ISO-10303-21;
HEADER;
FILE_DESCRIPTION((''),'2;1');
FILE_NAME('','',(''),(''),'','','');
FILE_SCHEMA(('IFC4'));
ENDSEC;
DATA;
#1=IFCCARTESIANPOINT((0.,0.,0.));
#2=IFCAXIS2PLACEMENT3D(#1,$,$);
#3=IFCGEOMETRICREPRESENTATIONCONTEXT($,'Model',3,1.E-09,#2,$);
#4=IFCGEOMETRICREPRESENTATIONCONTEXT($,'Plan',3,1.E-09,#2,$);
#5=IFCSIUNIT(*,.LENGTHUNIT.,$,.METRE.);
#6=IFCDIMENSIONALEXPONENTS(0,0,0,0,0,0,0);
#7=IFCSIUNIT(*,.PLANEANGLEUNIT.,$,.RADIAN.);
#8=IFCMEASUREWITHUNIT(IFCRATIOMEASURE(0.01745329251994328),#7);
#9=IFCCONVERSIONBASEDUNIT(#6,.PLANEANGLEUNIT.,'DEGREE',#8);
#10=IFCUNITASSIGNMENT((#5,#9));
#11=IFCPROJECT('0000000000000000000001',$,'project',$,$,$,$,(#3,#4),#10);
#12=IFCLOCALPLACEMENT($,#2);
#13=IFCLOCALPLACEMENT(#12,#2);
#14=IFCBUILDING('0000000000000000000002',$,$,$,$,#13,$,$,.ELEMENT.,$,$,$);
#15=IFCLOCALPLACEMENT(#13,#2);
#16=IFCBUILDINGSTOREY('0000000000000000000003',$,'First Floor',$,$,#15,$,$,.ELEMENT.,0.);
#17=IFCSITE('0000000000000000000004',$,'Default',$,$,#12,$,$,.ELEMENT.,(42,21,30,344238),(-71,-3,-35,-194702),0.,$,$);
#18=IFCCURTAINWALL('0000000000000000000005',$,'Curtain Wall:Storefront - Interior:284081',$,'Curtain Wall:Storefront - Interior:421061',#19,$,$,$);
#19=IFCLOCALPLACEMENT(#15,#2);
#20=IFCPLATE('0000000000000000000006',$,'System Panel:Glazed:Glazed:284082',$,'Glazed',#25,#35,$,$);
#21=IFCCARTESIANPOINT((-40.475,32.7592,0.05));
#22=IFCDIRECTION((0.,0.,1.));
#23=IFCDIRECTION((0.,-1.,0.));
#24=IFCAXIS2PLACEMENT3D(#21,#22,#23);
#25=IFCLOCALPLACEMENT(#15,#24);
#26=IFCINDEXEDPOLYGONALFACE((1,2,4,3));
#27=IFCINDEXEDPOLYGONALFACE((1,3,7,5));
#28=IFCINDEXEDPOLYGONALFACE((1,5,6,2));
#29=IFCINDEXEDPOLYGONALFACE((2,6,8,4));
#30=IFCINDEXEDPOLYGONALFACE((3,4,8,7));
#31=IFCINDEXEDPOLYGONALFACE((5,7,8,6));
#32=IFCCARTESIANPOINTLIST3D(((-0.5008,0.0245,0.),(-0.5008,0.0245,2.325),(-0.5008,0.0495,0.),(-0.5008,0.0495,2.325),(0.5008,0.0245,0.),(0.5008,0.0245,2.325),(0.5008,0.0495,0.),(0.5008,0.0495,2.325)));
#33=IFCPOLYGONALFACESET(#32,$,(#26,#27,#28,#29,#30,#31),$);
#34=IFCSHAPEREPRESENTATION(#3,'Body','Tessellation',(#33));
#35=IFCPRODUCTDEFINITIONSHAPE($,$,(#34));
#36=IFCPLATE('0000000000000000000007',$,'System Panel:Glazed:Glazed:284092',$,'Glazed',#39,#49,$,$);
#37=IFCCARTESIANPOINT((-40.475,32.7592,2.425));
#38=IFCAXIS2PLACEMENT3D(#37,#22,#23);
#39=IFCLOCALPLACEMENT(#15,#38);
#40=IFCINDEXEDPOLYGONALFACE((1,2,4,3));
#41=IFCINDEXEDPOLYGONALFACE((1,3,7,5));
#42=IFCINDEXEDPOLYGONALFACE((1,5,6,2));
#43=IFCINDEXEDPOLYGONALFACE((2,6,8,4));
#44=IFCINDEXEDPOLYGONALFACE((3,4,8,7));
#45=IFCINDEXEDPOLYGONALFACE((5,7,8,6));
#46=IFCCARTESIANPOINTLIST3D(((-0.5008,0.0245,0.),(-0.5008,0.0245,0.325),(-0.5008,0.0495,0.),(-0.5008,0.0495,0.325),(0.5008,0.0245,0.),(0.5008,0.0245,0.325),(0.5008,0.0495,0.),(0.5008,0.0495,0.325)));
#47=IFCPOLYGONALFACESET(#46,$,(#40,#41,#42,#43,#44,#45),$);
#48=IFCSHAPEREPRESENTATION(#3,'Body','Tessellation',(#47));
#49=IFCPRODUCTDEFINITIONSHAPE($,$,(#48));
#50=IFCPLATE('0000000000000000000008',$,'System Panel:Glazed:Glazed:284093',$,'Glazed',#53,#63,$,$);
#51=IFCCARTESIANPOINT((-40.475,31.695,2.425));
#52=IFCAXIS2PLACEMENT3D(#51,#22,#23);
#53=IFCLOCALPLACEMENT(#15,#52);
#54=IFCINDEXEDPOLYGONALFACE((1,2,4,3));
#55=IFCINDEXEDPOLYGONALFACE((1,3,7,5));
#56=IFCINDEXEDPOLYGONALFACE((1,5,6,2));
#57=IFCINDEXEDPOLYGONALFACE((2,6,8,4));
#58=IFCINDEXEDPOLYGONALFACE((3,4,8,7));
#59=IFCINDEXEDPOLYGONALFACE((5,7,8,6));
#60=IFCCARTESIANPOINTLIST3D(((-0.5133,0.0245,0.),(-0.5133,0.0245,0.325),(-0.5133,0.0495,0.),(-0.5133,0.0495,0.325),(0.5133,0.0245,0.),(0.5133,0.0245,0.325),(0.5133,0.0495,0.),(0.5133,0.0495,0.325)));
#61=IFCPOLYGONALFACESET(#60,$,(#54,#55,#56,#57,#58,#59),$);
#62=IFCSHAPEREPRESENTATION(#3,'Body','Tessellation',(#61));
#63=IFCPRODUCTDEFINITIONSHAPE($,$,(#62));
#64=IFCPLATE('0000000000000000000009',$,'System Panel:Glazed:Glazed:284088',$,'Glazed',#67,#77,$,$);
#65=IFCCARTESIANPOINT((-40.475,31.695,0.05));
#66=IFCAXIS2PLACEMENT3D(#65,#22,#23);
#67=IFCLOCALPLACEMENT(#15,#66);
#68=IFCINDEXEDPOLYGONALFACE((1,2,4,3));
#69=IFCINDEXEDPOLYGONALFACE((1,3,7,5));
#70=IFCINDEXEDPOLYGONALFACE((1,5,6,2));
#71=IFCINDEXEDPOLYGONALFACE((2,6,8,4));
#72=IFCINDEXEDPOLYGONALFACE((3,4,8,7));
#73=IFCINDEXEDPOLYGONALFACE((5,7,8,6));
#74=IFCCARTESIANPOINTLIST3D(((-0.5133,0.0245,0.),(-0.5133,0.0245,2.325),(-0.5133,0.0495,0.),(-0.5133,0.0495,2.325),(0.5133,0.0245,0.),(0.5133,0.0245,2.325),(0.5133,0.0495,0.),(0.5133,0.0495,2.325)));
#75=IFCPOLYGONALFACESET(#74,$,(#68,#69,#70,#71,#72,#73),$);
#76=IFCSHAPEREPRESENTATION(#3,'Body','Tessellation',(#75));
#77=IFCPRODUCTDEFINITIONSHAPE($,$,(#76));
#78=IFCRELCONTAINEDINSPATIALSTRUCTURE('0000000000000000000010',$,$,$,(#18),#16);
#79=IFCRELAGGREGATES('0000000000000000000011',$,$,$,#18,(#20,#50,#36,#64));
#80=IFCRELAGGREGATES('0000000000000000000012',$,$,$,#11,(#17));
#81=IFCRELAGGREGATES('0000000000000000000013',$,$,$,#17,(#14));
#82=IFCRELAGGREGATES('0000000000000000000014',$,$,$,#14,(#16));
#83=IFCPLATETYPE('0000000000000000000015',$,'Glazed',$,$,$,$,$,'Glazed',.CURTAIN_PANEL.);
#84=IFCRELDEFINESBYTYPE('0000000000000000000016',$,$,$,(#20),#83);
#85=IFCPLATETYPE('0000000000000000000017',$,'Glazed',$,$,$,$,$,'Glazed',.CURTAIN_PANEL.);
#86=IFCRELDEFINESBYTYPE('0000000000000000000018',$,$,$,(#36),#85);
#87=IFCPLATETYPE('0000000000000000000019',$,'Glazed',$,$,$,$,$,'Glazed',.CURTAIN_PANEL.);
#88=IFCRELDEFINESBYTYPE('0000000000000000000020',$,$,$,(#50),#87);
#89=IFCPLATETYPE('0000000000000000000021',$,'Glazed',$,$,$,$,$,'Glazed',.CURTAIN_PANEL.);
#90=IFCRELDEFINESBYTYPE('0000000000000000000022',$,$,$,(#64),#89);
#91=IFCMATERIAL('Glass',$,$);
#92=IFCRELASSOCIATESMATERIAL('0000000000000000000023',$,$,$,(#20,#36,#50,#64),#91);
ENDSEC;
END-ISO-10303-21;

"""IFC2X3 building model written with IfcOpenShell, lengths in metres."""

from ifc_helpers import new_model, entity, si_unit, converted_unit, frame, origin, origin_2d_with_axis, place, context, project, spatial, rectangle, extrude, source, transform, mapped, material, type_object, type_shapes, element, aggregate, save


model = new_model("IFC2X3")

# Units and contexts
model_context = context("Model", 3, precision=1e-09, world=origin())
plan_context = context("Plan", 3, precision=1e-09, world=origin())
ifc_project = project(units=[si_unit("LENGTHUNIT", "METRE"), converted_unit("PLANEANGLEUNIT", "DEGREE", entity("IfcRatioMeasure", 0.01745329251994328), si_unit("PLANEANGLEUNIT", "RADIAN"), dimensions=[0, 0, 0, 0, 0, 0, 0])], contexts=[model_context, plan_context])

# Site, building, storey
site_placement = place(None, origin())
site = spatial("IfcSite", under=ifc_project, at=site_placement, Name="Default", CompositionType="ELEMENT", RefLatitude=(42, 21, 30, 344238), RefLongitude=(-71, -3, -35, -194702), RefElevation=0.0)
building_placement = place(site_placement, origin())
building = spatial("IfcBuilding", under=site, at=building_placement, CompositionType="ELEMENT")
storey_placement = place(building_placement, origin())
storey = spatial("IfcBuildingStorey", under=building, at=storey_placement, Name="First Floor", CompositionType="ELEMENT", Elevation=0.0)

# Curtain wall, plates
curtain_wall_placement = place(storey_placement, origin())
curtain_wall = element("IfcCurtainWall", 1, at=curtain_wall_placement, inside=storey, Name="Curtain Wall:Storefront - Interior:284081", ObjectType="Curtain Wall:Storefront - Interior:421061")
ifc_material_1 = material(Name="Glass")
plate_type_1 = type_object("IfcPlateType", Name="Glazed", ElementType="Glazed", PredefinedType="CURTAIN_PANEL")
shared_shape_1 = source(origin(), model_context, "Body", "SweptSolid", [
    extrude(rectangle(XDim=0.025, YDim=1.0017, at=origin_2d_with_axis()), frame((0.0, 0.037, 0.0), z_axis=(0.0, 0.0, 1.0), x_axis=(0.0, 1.0, 0.0)), (0.0, 0.0, 1.0), 2.325),
])
type_shapes(plate_type_1, [shared_shape_1])
plate_1_placement = place(storey_placement, frame((-40.475, 32.7592, 0.05), z_axis=(0.0, 0.0, 1.0), x_axis=(0.0, -1.0, 0.0)))
plate_1 = element("IfcPlate", 2, at=plate_1_placement, type_object=plate_type_1, material=ifc_material_1, Name="System Panel:Glazed:Glazed:284082", ObjectType="Glazed", context=model_context, shape_type="MappedRepresentation", body=[
    mapped(shared_shape_1, transform((0.0, 0.0, 0.0), scale=1.0)),
])
plate_type_2 = type_object("IfcPlateType", Name="Glazed", ElementType="Glazed", PredefinedType="CURTAIN_PANEL")
shared_shape_2 = source(origin(), model_context, "Body", "SweptSolid", [
    extrude(rectangle(XDim=0.025, YDim=1.0017, at=origin_2d_with_axis()), frame((0.0, 0.037, 0.0), z_axis=(0.0, 0.0, 1.0), x_axis=(0.0, 1.0, 0.0)), (0.0, 0.0, 1.0), 0.325),
])
type_shapes(plate_type_2, [shared_shape_2])
plate_2_placement = place(storey_placement, frame((-40.475, 32.7592, 2.425), z_axis=(0.0, 0.0, 1.0), x_axis=(0.0, -1.0, 0.0)))
plate_2 = element("IfcPlate", 3, at=plate_2_placement, type_object=plate_type_2, material=ifc_material_1, Name="System Panel:Glazed:Glazed:284092", ObjectType="Glazed", context=model_context, shape_type="MappedRepresentation", body=[
    mapped(shared_shape_2, transform((0.0, 0.0, 0.0), scale=1.0)),
])
plate_type_3 = type_object("IfcPlateType", Name="Glazed", ElementType="Glazed", PredefinedType="CURTAIN_PANEL")
shared_shape_3 = source(origin(), model_context, "Body", "SweptSolid", [
    extrude(rectangle(XDim=0.025, YDim=1.0267, at=origin_2d_with_axis()), frame((0.0, 0.037, 0.0), z_axis=(0.0, 0.0, 1.0), x_axis=(0.0, 1.0, 0.0)), (0.0, 0.0, 1.0), 0.325),
])
type_shapes(plate_type_3, [shared_shape_3])
plate_3_placement = place(storey_placement, frame((-40.475, 31.695, 2.425), z_axis=(0.0, 0.0, 1.0), x_axis=(0.0, -1.0, 0.0)))
plate_3 = element("IfcPlate", 4, at=plate_3_placement, type_object=plate_type_3, material=ifc_material_1, Name="System Panel:Glazed:Glazed:284093", ObjectType="Glazed", context=model_context, shape_type="MappedRepresentation", body=[
    mapped(shared_shape_3, transform((0.0, 0.0, 0.0), scale=1.0)),
])
plate_type_4 = type_object("IfcPlateType", Name="Glazed", ElementType="Glazed", PredefinedType="CURTAIN_PANEL")
shared_shape_4 = source(origin(), model_context, "Body", "SweptSolid", [
    extrude(rectangle(XDim=0.025, YDim=1.0267, at=origin_2d_with_axis()), frame((0.0, 0.037, 0.0), z_axis=(0.0, 0.0, 1.0), x_axis=(0.0, 1.0, 0.0)), (0.0, 0.0, 1.0), 2.325),
])
type_shapes(plate_type_4, [shared_shape_4])
plate_4_placement = place(storey_placement, frame((-40.475, 31.695, 0.05), z_axis=(0.0, 0.0, 1.0), x_axis=(0.0, -1.0, 0.0)))
plate_4 = element("IfcPlate", 5, at=plate_4_placement, type_object=plate_type_4, material=ifc_material_1, Name="System Panel:Glazed:Glazed:284088", ObjectType="Glazed", context=model_context, shape_type="MappedRepresentation", body=[
    mapped(shared_shape_4, transform((0.0, 0.0, 0.0), scale=1.0)),
])
aggregate(curtain_wall, [plate_1, plate_3, plate_2, plate_4])

save(model, "model.ifc")
